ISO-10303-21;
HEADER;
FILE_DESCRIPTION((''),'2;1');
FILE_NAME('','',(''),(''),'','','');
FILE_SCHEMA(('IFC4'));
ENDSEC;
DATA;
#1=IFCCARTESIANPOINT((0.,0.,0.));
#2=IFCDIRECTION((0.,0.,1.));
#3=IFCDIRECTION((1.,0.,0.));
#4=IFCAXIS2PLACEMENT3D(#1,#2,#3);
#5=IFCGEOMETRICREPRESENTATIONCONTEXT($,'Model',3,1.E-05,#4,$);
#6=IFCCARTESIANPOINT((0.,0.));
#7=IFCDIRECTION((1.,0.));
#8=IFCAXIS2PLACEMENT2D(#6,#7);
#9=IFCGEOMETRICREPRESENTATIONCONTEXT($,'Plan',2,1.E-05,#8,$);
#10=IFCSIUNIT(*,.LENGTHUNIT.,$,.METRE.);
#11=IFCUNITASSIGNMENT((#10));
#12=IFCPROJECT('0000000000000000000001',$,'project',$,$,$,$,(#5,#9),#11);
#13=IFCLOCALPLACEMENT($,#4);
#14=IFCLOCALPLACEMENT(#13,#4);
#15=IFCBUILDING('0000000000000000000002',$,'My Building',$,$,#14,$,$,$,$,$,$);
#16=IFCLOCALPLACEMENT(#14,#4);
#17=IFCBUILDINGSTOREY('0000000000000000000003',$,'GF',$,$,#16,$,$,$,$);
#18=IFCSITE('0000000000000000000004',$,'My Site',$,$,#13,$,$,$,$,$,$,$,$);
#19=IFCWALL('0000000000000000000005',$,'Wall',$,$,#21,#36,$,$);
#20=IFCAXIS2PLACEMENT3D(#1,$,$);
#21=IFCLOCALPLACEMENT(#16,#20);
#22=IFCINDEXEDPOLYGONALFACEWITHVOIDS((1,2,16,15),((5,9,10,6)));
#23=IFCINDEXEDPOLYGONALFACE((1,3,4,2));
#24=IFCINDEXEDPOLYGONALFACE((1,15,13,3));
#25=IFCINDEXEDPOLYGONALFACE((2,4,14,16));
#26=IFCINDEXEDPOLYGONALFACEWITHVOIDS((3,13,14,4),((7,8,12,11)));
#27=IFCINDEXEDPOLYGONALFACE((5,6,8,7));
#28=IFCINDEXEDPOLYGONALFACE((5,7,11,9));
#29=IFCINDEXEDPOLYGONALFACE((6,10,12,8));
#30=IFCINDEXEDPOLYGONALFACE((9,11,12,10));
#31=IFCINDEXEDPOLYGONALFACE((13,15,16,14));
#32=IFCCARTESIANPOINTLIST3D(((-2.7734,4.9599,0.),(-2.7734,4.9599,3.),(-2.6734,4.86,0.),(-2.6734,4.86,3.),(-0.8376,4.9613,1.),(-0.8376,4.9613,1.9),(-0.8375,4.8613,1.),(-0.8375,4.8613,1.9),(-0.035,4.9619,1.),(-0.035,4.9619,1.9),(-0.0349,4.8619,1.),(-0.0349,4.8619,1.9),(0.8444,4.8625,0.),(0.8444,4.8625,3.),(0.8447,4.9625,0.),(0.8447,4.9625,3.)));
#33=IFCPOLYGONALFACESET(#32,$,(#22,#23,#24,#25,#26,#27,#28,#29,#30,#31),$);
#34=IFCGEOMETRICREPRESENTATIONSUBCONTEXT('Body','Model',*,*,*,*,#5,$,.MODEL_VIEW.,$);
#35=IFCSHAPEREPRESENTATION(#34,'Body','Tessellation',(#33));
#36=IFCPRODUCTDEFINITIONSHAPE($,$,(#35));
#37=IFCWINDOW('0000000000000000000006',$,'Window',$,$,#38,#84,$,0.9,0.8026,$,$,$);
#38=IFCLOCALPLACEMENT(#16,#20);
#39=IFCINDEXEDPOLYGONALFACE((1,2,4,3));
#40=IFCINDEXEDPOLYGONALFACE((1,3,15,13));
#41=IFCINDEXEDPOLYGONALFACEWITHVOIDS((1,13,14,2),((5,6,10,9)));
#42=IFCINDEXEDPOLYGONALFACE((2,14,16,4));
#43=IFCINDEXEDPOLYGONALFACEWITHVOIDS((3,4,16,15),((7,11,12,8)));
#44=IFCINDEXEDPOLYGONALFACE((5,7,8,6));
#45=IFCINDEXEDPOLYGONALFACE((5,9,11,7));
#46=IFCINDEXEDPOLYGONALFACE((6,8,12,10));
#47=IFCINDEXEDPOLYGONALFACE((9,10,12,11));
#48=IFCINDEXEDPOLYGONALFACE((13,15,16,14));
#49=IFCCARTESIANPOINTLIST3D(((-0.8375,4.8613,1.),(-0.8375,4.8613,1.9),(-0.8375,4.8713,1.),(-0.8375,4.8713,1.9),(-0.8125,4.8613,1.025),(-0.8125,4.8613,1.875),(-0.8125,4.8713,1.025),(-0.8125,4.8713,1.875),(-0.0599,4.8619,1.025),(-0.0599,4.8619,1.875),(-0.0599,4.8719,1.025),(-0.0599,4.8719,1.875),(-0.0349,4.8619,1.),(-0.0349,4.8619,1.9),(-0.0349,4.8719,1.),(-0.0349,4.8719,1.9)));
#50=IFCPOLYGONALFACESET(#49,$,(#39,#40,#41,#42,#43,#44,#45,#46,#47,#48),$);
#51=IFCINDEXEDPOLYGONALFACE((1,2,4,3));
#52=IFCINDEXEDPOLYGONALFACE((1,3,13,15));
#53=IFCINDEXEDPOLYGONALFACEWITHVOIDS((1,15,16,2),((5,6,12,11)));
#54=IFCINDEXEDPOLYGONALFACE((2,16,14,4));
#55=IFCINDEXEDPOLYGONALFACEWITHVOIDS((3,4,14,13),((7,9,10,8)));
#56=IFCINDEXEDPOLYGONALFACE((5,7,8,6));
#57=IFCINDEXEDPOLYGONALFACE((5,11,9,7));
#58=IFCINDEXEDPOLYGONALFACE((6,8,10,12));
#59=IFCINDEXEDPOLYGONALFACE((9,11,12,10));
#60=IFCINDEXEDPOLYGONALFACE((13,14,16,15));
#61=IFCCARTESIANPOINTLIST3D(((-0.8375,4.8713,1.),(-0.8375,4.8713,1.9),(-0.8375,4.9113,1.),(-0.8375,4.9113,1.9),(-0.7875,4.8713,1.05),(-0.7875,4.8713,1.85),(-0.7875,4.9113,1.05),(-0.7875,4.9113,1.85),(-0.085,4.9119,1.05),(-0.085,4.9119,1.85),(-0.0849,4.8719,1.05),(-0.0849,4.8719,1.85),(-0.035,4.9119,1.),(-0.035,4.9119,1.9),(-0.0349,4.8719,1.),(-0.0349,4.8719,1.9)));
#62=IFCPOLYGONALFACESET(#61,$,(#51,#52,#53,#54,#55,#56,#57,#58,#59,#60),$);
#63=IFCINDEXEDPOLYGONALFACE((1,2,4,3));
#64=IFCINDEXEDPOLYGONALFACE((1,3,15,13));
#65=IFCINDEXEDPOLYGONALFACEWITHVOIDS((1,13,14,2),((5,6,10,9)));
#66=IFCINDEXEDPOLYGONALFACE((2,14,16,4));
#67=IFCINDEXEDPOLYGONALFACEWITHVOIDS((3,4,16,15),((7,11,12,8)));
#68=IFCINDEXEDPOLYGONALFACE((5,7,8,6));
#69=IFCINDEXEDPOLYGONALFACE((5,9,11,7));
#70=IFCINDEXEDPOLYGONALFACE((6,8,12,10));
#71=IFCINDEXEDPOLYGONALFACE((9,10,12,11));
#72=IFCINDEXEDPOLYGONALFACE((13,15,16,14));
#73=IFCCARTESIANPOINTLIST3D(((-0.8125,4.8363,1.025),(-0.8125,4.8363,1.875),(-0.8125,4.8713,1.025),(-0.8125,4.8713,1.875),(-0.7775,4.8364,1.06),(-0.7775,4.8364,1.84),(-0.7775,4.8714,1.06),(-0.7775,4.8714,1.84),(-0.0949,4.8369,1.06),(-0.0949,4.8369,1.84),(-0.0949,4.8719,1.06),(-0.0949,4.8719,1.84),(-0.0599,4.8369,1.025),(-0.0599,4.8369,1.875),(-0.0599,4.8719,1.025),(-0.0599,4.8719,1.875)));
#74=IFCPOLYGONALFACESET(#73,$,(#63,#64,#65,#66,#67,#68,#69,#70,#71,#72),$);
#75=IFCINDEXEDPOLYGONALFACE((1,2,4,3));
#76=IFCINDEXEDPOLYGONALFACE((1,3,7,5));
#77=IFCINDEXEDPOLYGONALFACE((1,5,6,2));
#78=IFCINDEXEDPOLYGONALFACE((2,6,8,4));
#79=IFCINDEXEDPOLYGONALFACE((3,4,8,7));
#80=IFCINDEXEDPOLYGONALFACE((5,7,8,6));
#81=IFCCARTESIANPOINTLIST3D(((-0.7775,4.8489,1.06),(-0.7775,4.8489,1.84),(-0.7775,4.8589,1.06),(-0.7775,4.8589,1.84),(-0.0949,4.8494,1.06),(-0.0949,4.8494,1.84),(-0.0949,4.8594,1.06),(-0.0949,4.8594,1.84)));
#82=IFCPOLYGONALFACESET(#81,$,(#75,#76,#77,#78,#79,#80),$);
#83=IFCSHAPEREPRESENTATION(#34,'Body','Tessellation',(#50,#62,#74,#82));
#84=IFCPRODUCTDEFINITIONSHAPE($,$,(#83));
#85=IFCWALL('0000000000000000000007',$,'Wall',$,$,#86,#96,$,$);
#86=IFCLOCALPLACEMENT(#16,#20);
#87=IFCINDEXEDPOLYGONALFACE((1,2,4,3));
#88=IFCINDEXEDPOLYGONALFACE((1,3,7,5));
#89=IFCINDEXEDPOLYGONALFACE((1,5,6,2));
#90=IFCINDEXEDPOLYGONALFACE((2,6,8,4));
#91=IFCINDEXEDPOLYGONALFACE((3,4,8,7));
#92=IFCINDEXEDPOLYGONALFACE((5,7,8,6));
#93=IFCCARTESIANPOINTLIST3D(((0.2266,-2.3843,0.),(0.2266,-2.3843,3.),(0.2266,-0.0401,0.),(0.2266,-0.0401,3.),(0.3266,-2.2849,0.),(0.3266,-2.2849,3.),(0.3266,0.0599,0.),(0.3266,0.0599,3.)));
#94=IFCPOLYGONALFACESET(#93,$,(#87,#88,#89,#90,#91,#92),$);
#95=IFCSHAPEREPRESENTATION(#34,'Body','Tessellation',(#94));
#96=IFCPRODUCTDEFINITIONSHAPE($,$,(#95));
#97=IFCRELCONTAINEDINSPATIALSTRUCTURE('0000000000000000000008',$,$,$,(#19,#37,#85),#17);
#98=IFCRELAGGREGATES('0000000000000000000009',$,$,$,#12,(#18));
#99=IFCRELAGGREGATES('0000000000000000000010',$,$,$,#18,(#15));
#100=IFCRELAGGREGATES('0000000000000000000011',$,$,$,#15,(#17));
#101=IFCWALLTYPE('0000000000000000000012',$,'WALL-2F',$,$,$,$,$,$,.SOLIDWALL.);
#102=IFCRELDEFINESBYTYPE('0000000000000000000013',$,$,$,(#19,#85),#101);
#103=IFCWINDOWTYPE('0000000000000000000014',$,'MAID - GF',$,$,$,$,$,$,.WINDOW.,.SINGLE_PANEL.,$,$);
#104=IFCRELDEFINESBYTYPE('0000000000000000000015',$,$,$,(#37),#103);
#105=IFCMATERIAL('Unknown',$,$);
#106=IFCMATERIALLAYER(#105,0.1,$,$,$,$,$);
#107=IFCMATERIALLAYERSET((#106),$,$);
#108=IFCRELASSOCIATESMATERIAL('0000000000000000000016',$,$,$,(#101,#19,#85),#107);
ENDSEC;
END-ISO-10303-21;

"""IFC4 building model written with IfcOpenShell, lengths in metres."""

from ifc_helpers import new_model, entity, si_unit, frame, origin_with_axes, origin_2d_with_axis, place, context, subcontext, project, spatial, line, indexed_curve, outline, extrude, shape, source, transform, mapped, material, layer, layer_set, layer_usage, type_object, type_shapes, element, fill, save


model = new_model("IFC4")

# Units and contexts
model_context = context("Model", 3, precision=1e-05, world=origin_with_axes())
plan_context = context("Plan", 2, precision=1e-05, world=origin_2d_with_axis())
body_context_1 = subcontext(model_context, "Body", "Model", "MODEL_VIEW")
body_context_2 = subcontext(plan_context, "Body", "Plan", "PLAN_VIEW")
ifc_project = project(units=[si_unit("LENGTHUNIT", "METRE")], contexts=[model_context, plan_context])

# Site, building, storey
site_placement = place(None, origin_with_axes())
site = spatial("IfcSite", under=ifc_project, at=site_placement, Name="My Site")
building_placement = place(site_placement, origin_with_axes())
building = spatial("IfcBuilding", under=site, at=building_placement, Name="My Building")
storey_placement = place(building_placement, origin_with_axes())
storey = spatial("IfcBuildingStorey", under=building, at=storey_placement, Name="GF")

# Shared definitions
ifc_material_1 = material(Name="Unknown")

# Shared definitions
ifc_layer_1 = layer(ifc_material_1, 0.1)
ifc_layer_set_1 = layer_set([ifc_layer_1])
wall_type_1 = type_object("IfcWallType", Name="WALL-2F", PredefinedType="SOLIDWALL", material=ifc_layer_set_1)

# Wall, opening, window
ifc_layer_usage_1 = layer_usage(ifc_layer_set_1, "AXIS2", "POSITIVE", 0.0)
wall_1_placement = place(storey_placement, frame((-2.7734, 4.8599, 0.0), z_axis=(0.0, 0.0, 1.0), x_axis=(1.0, 0.000731, 0.0)))
wall_1 = element("IfcWall", 1, at=wall_1_placement, inside=storey, type_object=wall_type_1, material=ifc_layer_usage_1, Name="Wall", context=body_context_1, shape_type="SweptSolid", body=[
    extrude(outline(indexed_curve([(0.1, 0.0), (0.0001, 0.1), (3.6181, 0.1), (3.6178, 0.0)], segments=[line(1, 2, 3, 4, 1)])), origin_with_axes(), (0.0, 0.0, 1.0), 3.0),
])
shared_shape_1 = source(origin_with_axes(), body_context_1, "Body", "SweptSolid", [
    extrude(outline(indexed_curve([(0.0, 0.0), (0.8026, 0.0), (0.8026, 0.9), (0.0, 0.9)], segments=[line(1, 2, 3, 4, 1)])), frame((0.0, -0.6, 0.0), z_axis=(0.0, -1.0, 0.0), x_axis=(1.0, 0.0, 0.0)), (0.0, 0.0, -1.0), 1.2),
])
opening_1_placement = place(wall_1_placement, frame((2.7385, 0.1, 1.0), z_axis=(0.0, 0.0, 1.0), x_axis=(-1.0, 0.0, 0.0)))
opening_1 = element("IfcOpeningElement", 2, at=opening_1_placement, cuts=wall_1, PredefinedType="OPENING", context=body_context_1, shape_type="MappedRepresentation", body=[
    mapped(shared_shape_1, transform((0.0, 0.0, 0.0), x_axis=(1.0, 0.0, 0.0), y_axis=(0.0, 1.0, 0.0), z_axis=(0.0, 0.0, 1.0), scale=1.0)),
])
window_type_1 = type_object("IfcWindowType", Name="MAID - GF", PartitioningType="SINGLE_PANEL", PredefinedType="WINDOW")
shared_shape_2 = source(origin_with_axes(), body_context_1, "Body", "SweptSolid", [
    extrude(outline(indexed_curve([(0.0, 0.0), (0.8026, 0.0), (0.8026, 0.9), (0.0, 0.9)], segments=[line(1, 2, 3, 4, 1)]), holes=[indexed_curve([(0.025, 0.025), (0.7776, 0.025), (0.7776, 0.875), (0.025, 0.875)], segments=[line(1, 2, 3, 4, 1)])]), frame((0.0, 0.09, 0.0), z_axis=(0.0, -1.0, 0.0), x_axis=(1.0, 0.0, 0.0)), (0.0, 0.0, -1.0), 0.01),
    extrude(outline(indexed_curve([(0.0, 0.0), (0.8026, 0.0), (0.8026, 0.9), (0.0, 0.9)], segments=[line(1, 2, 3, 4, 1)]), holes=[indexed_curve([(0.05, 0.05), (0.7526, 0.05), (0.7526, 0.85), (0.05, 0.85)], segments=[line(1, 2, 3, 4, 1)])]), frame((0.0, 0.05, 0.0), z_axis=(0.0, -1.0, 0.0), x_axis=(1.0, 0.0, 0.0)), (0.0, 0.0, -1.0), 0.04),
    extrude(outline(indexed_curve([(0.0, 0.0), (0.7526, 0.0), (0.7526, 0.85), (0.0, 0.85)], segments=[line(1, 2, 3, 4, 1)]), holes=[indexed_curve([(0.035, 0.035), (0.7176, 0.035), (0.7176, 0.815), (0.035, 0.815)], segments=[line(1, 2, 3, 4, 1)])]), frame((0.025, 0.09, 0.025), z_axis=(0.0, -1.0, 0.0), x_axis=(1.0, 0.0, 0.0)), (0.0, 0.0, -1.0), 0.035),
    extrude(outline(indexed_curve([(0.035, 0.035), (0.7176, 0.035), (0.7176, 0.815), (0.035, 0.815)], segments=[line(1, 2, 3, 4, 1)])), frame((0.025, 0.1025, 0.025), z_axis=(0.0, -1.0, 0.0), x_axis=(1.0, 0.0, 0.0)), (0.0, 0.0, -1.0), 0.01),
])
shared_shape_3 = source(origin_with_axes(), body_context_2, "Body", "Curve2D", [
    entity("IfcIndexedPolyCurve", entity("IfcCartesianPointList2D", [[0.05, 0.05], [0.7526, 0.05]])),
    entity("IfcIndexedPolyCurve", entity("IfcCartesianPointList2D", [[0.0, 0.1], [0.025, 0.1], [0.025, 0.09], [0.05, 0.09], [0.05, 0.05], [0.0, 0.05]]), [entity("IfcLineIndex", [1, 2, 3, 4, 5, 6, 1])]),
    entity("IfcIndexedPolyCurve", entity("IfcCartesianPointList2D", [[0.8026, 0.1], [0.7776, 0.1], [0.7776, 0.09], [0.7526, 0.09], [0.7526, 0.05], [0.8026, 0.05]]), [entity("IfcLineIndex", [1, 2, 3, 4, 5, 6, 1])]),
    entity("IfcIndexedPolyCurve", entity("IfcCartesianPointList2D", [[0.025, 0.09], [0.06, 0.09], [0.06, 0.125], [0.025, 0.125]]), [entity("IfcLineIndex", [1, 2, 3, 4, 1])]),
    entity("IfcIndexedPolyCurve", entity("IfcCartesianPointList2D", [[0.7776, 0.09], [0.7426, 0.09], [0.7426, 0.125], [0.7776, 0.125]]), [entity("IfcLineIndex", [1, 2, 3, 4, 1])]),
    entity("IfcIndexedPolyCurve", entity("IfcCartesianPointList2D", [[0.06, 0.09], [0.7426, 0.09]])),
    entity("IfcIndexedPolyCurve", entity("IfcCartesianPointList2D", [[0.06, 0.125], [0.7426, 0.125]])),
    entity("IfcIndexedPolyCurve", entity("IfcCartesianPointList2D", [[0.06, 0.1075], [0.7426, 0.1075]])),
])
type_shapes(window_type_1, [shared_shape_2, shared_shape_3])
window_1_placement = place(opening_1_placement, frame((0.0, 0.0, 0.0), z_axis=(0.0, 0.0, 1.0), x_axis=(1.0, 0.0, 0.0)))
window_1 = element("IfcWindow", 3, at=window_1_placement, inside=storey, type_object=window_type_1, Name="Window", OverallHeight=0.9, OverallWidth=0.8026, shapes=[
    shape(body_context_1, "Body", "MappedRepresentation", [mapped(shared_shape_2, transform((0.0, 0.0, 0.0), x_axis=(1.0, 0.0, 0.0), y_axis=(0.0, 1.0, 0.0), z_axis=(0.0, 0.0, 1.0), scale=1.0))]),
    shape(body_context_2, "Body", "MappedRepresentation", [mapped(shared_shape_3, transform((0.0, 0.0, 0.0), x_axis=(1.0, 0.0, 0.0), y_axis=(0.0, 1.0, 0.0), z_axis=(0.0, 0.0, 1.0), scale=1.0))]),
])
fill(opening_1, window_1)

# Wall
ifc_layer_usage_2 = layer_usage(ifc_layer_set_1, "AXIS2", "POSITIVE", 0.0)
wall_2_placement = place(storey_placement, frame((0.2266, -0.0401, 0.0), z_axis=(0.0, 0.0, 1.0), x_axis=(0.0, -1.0, 0.0)))
element("IfcWall", 4, at=wall_2_placement, inside=storey, type_object=wall_type_1, material=ifc_layer_usage_2, Name="Wall", context=body_context_1, shape_type="SweptSolid", body=[
    extrude(outline(indexed_curve([(0.0, 0.0), (-0.1, 0.1), (2.2448, 0.1), (2.3442, 0.0)], segments=[line(1, 2, 3, 4, 1)])), origin_with_axes(), (0.0, 0.0, 1.0), 3.0),
])

save(model, "model.ifc")
